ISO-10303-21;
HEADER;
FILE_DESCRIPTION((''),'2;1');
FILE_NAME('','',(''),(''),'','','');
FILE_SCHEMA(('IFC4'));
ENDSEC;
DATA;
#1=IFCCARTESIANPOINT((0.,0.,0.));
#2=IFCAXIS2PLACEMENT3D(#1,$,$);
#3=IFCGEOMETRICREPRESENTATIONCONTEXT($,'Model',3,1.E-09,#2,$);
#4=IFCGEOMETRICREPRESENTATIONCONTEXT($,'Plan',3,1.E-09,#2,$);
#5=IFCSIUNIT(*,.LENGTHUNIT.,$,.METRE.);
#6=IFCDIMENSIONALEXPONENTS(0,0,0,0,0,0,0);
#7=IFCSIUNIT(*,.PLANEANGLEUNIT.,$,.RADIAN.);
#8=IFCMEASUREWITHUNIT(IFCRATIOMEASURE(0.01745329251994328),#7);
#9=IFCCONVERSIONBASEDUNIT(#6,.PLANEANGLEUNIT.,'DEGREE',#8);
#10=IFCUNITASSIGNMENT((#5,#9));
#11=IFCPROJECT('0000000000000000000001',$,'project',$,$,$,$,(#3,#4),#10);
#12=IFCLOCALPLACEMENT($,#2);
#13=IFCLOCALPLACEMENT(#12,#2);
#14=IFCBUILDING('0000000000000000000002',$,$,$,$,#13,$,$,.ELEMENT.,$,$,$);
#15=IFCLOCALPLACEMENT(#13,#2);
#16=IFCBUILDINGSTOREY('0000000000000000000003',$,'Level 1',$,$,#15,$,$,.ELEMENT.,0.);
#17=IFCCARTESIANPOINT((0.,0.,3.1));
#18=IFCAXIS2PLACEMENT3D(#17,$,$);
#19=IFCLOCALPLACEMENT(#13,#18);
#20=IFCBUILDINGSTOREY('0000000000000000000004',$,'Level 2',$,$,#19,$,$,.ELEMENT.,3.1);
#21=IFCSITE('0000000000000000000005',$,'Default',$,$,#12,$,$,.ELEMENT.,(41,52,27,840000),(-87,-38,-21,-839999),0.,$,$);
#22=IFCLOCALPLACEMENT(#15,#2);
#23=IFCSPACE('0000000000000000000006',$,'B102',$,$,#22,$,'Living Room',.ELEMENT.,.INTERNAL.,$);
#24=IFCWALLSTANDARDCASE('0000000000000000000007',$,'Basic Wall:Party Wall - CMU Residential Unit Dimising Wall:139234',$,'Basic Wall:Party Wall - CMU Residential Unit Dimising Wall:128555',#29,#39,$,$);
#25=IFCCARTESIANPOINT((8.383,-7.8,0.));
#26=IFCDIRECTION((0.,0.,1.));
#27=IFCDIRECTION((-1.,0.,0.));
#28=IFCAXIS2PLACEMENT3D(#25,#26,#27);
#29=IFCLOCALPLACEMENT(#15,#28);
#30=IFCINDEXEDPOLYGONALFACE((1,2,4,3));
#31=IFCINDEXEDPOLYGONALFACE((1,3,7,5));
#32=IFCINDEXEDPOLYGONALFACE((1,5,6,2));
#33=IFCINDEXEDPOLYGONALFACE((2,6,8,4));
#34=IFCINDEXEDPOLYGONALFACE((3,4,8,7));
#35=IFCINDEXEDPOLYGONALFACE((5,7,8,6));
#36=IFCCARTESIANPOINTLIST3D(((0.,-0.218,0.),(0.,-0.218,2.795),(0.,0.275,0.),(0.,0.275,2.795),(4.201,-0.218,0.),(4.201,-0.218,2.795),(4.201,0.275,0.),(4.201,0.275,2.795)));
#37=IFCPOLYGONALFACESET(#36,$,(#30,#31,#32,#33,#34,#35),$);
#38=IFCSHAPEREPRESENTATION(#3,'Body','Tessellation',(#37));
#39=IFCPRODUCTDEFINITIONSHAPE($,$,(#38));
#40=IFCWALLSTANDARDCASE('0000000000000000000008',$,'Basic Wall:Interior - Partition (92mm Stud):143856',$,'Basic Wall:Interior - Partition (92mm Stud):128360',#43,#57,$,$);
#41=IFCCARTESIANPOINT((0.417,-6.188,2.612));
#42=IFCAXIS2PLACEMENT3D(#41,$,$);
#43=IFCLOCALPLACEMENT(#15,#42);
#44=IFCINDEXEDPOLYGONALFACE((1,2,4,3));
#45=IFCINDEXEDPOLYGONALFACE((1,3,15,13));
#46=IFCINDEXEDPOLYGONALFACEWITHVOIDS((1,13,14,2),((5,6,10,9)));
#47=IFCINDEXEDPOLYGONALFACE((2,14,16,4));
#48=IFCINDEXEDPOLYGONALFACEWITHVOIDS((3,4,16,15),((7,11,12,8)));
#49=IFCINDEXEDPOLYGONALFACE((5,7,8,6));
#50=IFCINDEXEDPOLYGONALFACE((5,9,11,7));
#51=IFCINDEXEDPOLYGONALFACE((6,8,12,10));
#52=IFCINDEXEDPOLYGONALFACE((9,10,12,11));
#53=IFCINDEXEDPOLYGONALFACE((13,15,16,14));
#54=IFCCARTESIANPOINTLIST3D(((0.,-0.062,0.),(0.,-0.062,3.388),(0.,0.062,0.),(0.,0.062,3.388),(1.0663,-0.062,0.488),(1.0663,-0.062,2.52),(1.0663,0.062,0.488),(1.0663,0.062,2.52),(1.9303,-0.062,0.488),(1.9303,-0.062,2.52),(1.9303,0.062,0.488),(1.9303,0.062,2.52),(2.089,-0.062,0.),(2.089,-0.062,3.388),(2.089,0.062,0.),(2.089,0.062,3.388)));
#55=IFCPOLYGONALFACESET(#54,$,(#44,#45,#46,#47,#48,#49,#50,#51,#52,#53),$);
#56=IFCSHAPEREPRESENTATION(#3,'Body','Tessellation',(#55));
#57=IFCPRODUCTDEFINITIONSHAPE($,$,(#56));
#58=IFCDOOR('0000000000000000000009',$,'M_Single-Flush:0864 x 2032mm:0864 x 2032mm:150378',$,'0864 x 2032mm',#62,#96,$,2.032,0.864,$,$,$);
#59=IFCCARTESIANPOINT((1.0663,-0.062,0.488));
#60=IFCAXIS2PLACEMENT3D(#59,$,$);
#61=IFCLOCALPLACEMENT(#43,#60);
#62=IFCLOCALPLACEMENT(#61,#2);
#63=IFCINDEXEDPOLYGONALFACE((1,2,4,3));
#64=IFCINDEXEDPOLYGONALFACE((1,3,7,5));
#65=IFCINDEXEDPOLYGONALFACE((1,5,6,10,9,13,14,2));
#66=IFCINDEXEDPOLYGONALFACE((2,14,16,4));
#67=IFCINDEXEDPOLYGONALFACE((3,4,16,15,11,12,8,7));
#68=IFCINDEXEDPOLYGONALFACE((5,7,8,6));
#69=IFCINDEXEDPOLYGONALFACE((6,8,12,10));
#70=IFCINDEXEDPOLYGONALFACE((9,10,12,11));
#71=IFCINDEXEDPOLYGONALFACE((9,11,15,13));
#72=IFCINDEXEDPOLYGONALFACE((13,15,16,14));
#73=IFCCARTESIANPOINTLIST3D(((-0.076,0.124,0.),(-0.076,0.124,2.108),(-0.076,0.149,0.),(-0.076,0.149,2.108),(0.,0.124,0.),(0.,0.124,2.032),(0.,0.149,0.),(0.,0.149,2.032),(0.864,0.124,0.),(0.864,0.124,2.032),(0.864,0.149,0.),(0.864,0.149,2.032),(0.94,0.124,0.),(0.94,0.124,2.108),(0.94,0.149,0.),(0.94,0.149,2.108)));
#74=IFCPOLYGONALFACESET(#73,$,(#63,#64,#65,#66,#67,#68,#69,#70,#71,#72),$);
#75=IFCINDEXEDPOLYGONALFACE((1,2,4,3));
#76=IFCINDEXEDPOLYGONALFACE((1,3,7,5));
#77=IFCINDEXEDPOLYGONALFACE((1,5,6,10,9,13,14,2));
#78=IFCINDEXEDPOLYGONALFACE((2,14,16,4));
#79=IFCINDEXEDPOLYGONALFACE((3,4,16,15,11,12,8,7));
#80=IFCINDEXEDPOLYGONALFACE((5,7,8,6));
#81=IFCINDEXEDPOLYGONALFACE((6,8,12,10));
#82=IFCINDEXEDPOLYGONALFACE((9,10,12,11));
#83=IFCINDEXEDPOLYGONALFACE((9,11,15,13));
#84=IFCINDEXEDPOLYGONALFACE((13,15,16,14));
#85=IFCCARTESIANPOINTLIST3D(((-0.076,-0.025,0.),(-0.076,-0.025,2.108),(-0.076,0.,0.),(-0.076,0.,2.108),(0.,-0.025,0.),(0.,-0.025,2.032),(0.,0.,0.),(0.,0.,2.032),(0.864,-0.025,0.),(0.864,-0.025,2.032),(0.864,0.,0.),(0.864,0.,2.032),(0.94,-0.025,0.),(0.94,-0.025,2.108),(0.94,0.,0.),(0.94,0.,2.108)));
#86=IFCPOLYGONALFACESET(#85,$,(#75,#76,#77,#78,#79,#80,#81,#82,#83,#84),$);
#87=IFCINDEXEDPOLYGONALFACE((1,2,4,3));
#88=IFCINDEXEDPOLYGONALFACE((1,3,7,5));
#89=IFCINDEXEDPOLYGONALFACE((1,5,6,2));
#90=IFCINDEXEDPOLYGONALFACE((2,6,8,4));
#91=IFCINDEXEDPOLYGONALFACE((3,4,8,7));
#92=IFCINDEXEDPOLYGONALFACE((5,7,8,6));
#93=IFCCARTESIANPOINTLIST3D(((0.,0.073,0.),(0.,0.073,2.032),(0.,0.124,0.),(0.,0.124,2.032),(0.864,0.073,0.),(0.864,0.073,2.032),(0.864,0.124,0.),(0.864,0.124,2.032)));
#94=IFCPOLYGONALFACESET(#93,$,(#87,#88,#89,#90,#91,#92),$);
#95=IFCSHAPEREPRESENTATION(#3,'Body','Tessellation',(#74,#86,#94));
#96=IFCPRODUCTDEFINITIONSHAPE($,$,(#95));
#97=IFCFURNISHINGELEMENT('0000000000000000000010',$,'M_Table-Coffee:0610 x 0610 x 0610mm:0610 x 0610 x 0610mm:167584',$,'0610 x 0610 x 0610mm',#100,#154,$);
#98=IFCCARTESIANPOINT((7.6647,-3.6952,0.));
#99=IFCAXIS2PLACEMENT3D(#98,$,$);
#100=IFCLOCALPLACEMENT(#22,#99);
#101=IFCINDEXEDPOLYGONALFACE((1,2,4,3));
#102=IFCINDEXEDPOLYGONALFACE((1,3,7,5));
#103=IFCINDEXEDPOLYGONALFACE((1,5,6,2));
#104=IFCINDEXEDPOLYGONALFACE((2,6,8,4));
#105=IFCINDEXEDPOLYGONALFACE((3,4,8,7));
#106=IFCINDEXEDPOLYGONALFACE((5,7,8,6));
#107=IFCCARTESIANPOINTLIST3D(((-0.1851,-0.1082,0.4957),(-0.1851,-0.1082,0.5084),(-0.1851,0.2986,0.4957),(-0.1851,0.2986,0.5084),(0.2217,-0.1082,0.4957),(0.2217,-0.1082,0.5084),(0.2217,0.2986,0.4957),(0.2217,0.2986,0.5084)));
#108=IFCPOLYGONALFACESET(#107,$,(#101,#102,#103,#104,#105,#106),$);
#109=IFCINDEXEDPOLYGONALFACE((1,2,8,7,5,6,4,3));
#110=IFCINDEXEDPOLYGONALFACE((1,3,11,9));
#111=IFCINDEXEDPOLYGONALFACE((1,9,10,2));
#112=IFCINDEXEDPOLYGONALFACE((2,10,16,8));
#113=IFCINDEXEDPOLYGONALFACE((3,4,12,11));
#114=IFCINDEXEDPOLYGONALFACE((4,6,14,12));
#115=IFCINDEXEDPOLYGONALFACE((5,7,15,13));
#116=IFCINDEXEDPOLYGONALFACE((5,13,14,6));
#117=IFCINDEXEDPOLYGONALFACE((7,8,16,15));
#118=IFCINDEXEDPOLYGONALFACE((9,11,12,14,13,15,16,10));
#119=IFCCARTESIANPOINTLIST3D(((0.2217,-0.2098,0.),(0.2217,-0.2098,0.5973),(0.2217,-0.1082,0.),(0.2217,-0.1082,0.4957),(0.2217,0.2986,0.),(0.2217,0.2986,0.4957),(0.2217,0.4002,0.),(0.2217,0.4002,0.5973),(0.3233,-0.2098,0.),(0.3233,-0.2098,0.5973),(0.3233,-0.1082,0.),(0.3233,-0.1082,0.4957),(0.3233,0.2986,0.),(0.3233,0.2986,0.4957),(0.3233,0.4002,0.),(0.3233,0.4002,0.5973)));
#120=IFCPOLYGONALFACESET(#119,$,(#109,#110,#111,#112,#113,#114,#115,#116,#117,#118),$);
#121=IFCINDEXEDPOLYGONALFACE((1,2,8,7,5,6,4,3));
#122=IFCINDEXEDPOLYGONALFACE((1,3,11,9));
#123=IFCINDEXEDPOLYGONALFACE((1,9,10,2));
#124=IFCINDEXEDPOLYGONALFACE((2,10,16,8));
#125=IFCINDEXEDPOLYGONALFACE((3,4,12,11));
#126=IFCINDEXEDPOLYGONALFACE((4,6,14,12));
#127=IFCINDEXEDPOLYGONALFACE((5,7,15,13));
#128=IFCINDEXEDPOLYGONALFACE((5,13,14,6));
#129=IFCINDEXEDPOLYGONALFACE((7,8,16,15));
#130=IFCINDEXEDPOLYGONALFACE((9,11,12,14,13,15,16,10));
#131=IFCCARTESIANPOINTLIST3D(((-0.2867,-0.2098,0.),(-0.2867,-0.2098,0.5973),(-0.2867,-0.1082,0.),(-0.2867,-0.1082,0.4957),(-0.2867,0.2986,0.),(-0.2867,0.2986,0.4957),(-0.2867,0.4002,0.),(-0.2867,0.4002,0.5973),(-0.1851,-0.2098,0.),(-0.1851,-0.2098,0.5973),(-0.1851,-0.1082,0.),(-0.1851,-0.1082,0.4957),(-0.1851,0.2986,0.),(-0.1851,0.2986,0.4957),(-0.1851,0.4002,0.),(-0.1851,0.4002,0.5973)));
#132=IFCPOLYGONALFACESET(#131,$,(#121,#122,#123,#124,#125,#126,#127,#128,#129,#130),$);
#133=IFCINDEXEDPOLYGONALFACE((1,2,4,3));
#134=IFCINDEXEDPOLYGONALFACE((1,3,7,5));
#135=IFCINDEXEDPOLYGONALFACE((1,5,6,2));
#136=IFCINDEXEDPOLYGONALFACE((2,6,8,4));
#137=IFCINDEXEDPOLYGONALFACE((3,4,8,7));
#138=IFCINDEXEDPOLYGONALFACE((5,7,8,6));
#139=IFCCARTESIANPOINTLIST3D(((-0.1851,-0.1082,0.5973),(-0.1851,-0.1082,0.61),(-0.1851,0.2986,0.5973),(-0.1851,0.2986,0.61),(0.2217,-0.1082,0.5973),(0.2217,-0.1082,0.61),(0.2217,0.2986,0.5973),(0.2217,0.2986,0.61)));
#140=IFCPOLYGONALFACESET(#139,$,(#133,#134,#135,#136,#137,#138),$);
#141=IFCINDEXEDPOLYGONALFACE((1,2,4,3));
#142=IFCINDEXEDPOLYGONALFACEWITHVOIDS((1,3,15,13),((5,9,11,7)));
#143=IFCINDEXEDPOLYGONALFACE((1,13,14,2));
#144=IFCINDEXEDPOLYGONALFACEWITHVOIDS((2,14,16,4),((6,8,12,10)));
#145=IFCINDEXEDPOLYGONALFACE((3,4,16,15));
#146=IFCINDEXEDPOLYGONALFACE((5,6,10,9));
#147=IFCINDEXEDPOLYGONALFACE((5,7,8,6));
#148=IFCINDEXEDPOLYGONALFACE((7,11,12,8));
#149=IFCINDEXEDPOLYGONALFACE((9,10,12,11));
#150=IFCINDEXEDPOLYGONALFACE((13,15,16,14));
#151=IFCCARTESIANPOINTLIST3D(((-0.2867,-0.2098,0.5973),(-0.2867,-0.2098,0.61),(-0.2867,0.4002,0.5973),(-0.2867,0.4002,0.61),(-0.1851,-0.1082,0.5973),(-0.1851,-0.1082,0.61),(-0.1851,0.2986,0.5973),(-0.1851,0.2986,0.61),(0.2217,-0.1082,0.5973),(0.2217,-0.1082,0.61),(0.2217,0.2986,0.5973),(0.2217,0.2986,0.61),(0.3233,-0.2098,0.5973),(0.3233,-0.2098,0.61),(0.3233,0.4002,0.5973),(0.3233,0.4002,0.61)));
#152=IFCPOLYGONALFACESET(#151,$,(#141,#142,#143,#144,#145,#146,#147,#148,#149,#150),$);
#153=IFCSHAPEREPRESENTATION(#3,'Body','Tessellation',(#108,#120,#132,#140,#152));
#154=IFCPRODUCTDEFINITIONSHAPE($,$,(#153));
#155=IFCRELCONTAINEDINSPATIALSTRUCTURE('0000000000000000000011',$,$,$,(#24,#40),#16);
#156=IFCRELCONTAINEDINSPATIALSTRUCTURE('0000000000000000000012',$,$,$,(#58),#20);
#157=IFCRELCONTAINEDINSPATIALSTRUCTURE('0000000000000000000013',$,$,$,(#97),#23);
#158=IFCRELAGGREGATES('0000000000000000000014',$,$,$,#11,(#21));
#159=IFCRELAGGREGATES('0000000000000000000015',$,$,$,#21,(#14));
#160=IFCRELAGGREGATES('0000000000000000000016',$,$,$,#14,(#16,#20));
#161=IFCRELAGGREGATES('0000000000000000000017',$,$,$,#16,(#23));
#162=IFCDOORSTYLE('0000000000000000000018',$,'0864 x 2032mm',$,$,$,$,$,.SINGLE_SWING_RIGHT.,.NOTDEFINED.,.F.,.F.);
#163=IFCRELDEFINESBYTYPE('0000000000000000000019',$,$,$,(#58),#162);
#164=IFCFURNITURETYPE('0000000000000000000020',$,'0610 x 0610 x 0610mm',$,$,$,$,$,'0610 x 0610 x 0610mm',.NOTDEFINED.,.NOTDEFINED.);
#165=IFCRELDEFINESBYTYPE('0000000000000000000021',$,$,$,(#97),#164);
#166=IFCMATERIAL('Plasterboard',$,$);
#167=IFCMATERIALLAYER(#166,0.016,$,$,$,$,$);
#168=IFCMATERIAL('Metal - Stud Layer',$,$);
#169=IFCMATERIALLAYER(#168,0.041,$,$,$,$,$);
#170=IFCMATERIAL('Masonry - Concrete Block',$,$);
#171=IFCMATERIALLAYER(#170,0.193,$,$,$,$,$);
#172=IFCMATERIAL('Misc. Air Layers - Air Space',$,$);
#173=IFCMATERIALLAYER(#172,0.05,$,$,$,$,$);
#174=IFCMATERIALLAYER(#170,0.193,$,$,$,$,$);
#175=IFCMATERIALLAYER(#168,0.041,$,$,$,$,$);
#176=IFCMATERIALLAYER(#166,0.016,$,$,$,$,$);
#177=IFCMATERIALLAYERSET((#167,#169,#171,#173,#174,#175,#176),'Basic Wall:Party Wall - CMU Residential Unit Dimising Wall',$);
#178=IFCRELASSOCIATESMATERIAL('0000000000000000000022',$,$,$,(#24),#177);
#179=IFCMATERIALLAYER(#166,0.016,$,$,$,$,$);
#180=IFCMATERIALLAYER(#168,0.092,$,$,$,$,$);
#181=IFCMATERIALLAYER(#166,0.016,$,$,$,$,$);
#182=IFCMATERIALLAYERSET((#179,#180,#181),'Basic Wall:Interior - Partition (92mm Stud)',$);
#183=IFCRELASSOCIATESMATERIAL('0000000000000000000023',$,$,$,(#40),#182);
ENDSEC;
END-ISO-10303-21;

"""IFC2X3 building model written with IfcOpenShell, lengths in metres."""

from ifc_helpers import new_model, entity, si_unit, converted_unit, frame, frame_2d, origin, origin_2d_with_axis, place, context, project, spatial, polyline, rectangle, outline, extrude, clip, bounded_halfspace, source, transform, mapped, material, layer, layer_set, layer_usage, type_object, type_shapes, element, fill, save


model = new_model("IFC2X3")

# Units and contexts
model_context = context("Model", 3, precision=1e-09, world=origin())
plan_context = context("Plan", 3, precision=1e-09, world=origin())
ifc_project = project(units=[si_unit("LENGTHUNIT", "METRE"), converted_unit("PLANEANGLEUNIT", "DEGREE", entity("IfcRatioMeasure", 0.01745329251994328), si_unit("PLANEANGLEUNIT", "RADIAN"), dimensions=[0, 0, 0, 0, 0, 0, 0])], contexts=[model_context, plan_context])

# Site, building, storey
site_placement = place(None, origin())
site = spatial("IfcSite", under=ifc_project, at=site_placement, Name="Default", CompositionType="ELEMENT", RefLatitude=(41, 52, 27, 840000), RefLongitude=(-87, -38, -21, -839999), RefElevation=0.0)
building_placement = place(site_placement, origin())
building = spatial("IfcBuilding", under=site, at=building_placement, CompositionType="ELEMENT")
storey_1_placement = place(building_placement, origin())
storey_1 = spatial("IfcBuildingStorey", under=building, at=storey_1_placement, Name="Level 1", CompositionType="ELEMENT", Elevation=0.0)

# Shared definitions
ifc_material_1 = material(Name="Misc. Air Layers - Air Space")
ifc_material_2 = material(Name="Masonry - Concrete Block")
ifc_material_3 = material(Name="Metal - Stud Layer")
ifc_material_4 = material(Name="Plasterboard")

# Wall
ifc_layer_1 = layer(ifc_material_4, 0.016)
ifc_layer_2 = layer(ifc_material_3, 0.041)
ifc_layer_3 = layer(ifc_material_2, 0.193)
ifc_layer_4 = layer(ifc_material_1, 0.05)
ifc_layer_5 = layer(ifc_material_2, 0.193)
ifc_layer_6 = layer(ifc_material_3, 0.041)
ifc_layer_7 = layer(ifc_material_4, 0.016)
ifc_layer_set_1 = layer_set([ifc_layer_1, ifc_layer_2, ifc_layer_3, ifc_layer_4, ifc_layer_5, ifc_layer_6, ifc_layer_7], Name="Basic Wall:Party Wall - CMU Residential Unit Dimising Wall")
ifc_layer_usage_1 = layer_usage(ifc_layer_set_1, "AXIS2", "NEGATIVE", 0.275)
wall_1_placement = place(storey_1_placement, frame((8.383, -7.8, 0.0), z_axis=(0.0, 0.0, 1.0), x_axis=(-1.0, 0.0, 0.0)))
element("IfcWallStandardCase", 1, at=wall_1_placement, inside=storey_1, material=ifc_layer_usage_1, Name="Basic Wall:Party Wall - CMU Residential Unit Dimising Wall:139234", ObjectType="Basic Wall:Party Wall - CMU Residential Unit Dimising Wall:128555", context=model_context, shape_type="Clipping", body=[
    clip(clip(extrude(rectangle(XDim=4.201, YDim=0.55, at=frame_2d((2.1005, 0.0), x_axis=(-1.0, 0.0))), origin(), (0.0, 0.0, 1.0), 2.795), bounded_halfspace(frame((0.0, -0.218, 2.795), z_axis=(0.0, 1.0, 0.0), x_axis=(-1.0, 0.0, 0.0)), True, frame((0.0, -0.218, 2.795), z_axis=(0.0, 1.0, 0.0), x_axis=(-1.0, 0.0, 0.0)), polyline([(0.0, 0.0), (-3.708, 0.0), (-4.201, 0.0), (-4.201, -2.795), (0.0, -2.795), (0.0, 0.0)]))), bounded_halfspace(frame((4.201, 0.275, 0.0), z_axis=(-1.0, 0.0, 0.0), x_axis=(0.0, -1.0, 0.0)), True, frame((4.201, 0.275, 0.0), z_axis=(-1.0, 0.0, 0.0), x_axis=(0.0, -1.0, 0.0)), polyline([(0.0, 0.0), (0.493, 0.0), (0.493, 2.795), (0.0, 2.795), (0.0, 0.0)]))),
])

# Wall, opening
ifc_layer_8 = layer(ifc_material_4, 0.016)
ifc_layer_9 = layer(ifc_material_3, 0.092)
ifc_layer_10 = layer(ifc_material_4, 0.016)
ifc_layer_set_2 = layer_set([ifc_layer_8, ifc_layer_9, ifc_layer_10], Name="Basic Wall:Interior - Partition (92mm Stud)")
ifc_layer_usage_2 = layer_usage(ifc_layer_set_2, "AXIS2", "NEGATIVE", 0.062)
wall_2_placement = place(storey_1_placement, frame((0.417, -6.188, 2.612)))
wall_2 = element("IfcWallStandardCase", 2, at=wall_2_placement, inside=storey_1, material=ifc_layer_usage_2, Name="Basic Wall:Interior - Partition (92mm Stud):143856", ObjectType="Basic Wall:Interior - Partition (92mm Stud):128360", context=model_context, shape_type="SweptSolid", body=[
    extrude(rectangle(XDim=2.089, YDim=0.124, at=frame_2d((1.0445, 0.0), x_axis=(-1.0, 0.0))), origin(), (0.0, 0.0, 1.0), 3.388),
])
opening_1_placement = place(wall_2_placement, frame((1.0663, -0.062, 0.488)))
opening_1 = element("IfcOpeningElement", 3, at=opening_1_placement, cuts=wall_2, ObjectType="Opening", context=model_context, shape_type="SweptSolid", body=[
    extrude(rectangle(XDim=0.864, YDim=2.032, at=frame_2d((1.016, 0.432), x_axis=(0.0, 1.0))), frame((0.0, 0.0, 0.0), z_axis=(0.0, 1.0, 0.0), x_axis=(0.0, 0.0, 1.0)), (0.0, 0.0, 1.0), 0.124),
])

# Shared definitions
storey_2_placement = place(building_placement, frame((0.0, 0.0, 3.1)))
storey_2 = spatial("IfcBuildingStorey", under=building, at=storey_2_placement, Name="Level 2", CompositionType="ELEMENT", Elevation=3.1)

# Door
door_style_1 = type_object("IfcDoorStyle", Name="0864 x 2032mm", ConstructionType="NOTDEFINED", OperationType="SINGLE_SWING_RIGHT", ParameterTakesPrecedence=False, Sizeable=False)
shared_shape_1 = source(origin(), model_context, "Body", "SweptSolid", [
    extrude(outline(polyline([(-0.508, -1.073), (0.508, -1.073), (0.508, 1.035), (0.432, 1.035), (0.432, -0.997), (-0.432, -0.997), (-0.432, 1.035), (-0.508, 1.035), (-0.508, -1.073)])), frame((0.432, 0.124, 1.035), z_axis=(0.0, 1.0, 0.0), x_axis=(1.0, 0.0, 0.0)), (0.0, 0.0, 1.0), 0.025),
    extrude(outline(polyline([(-1.073, -0.508), (1.035, -0.508), (1.035, -0.432), (-0.997, -0.432), (-0.997, 0.432), (1.035, 0.432), (1.035, 0.508), (-1.073, 0.508), (-1.073, -0.508)])), frame((0.432, -0.025, 1.035), z_axis=(0.0, 1.0, 0.0), x_axis=(0.0, 0.0, -1.0)), (0.0, 0.0, 1.0), 0.025),
    extrude(rectangle(XDim=0.051, YDim=0.864, at=origin_2d_with_axis()), frame((0.432, 0.0985, 0.0), z_axis=(0.0, 0.0, 1.0), x_axis=(0.0, 1.0, 0.0)), (0.0, 0.0, 1.0), 2.032),
])
type_shapes(door_style_1, [shared_shape_1])
door_1_placement = place(opening_1_placement, origin())
door_1 = element("IfcDoor", 4, at=door_1_placement, inside=storey_2, type_object=door_style_1, Name="M_Single-Flush:0864 x 2032mm:0864 x 2032mm:150378", ObjectType="0864 x 2032mm", OverallHeight=2.032, OverallWidth=0.864, context=model_context, shape_type="MappedRepresentation", body=[
    mapped(shared_shape_1, transform((0.0, 0.0, 0.0), scale=1.0)),
])
fill(opening_1, door_1)

# Shared definitions
space_1_placement = place(storey_1_placement, origin())
space_1 = spatial("IfcSpace", under=storey_1, at=space_1_placement, Name="B102", LongName="Living Room", CompositionType="ELEMENT", InteriorOrExteriorSpace="INTERNAL")

# Furnishing element
furniture_type_1 = type_object("IfcFurnitureType", Name="0610 x 0610 x 0610mm", ElementType="0610 x 0610 x 0610mm", AssemblyPlace="NOTDEFINED")
shared_shape_2 = source(origin(), model_context, "Body", "SweptSolid", [
    extrude(rectangle(XDim=0.4068, YDim=0.4068, at=origin_2d_with_axis()), frame((0.0183, 0.0952, 0.4957), z_axis=(0.0, 0.0, 1.0), x_axis=(-1.0, 0.0, 0.0)), (0.0, 0.0, 1.0), 0.0127),
    extrude(outline(polyline([(-0.2732, -0.305), (0.324, -0.305), (0.324, 0.305), (-0.2732, 0.305), (-0.2732, 0.2034), (0.2225, 0.2034), (0.2225, -0.2034), (-0.2732, -0.2034), (-0.2732, -0.305)])), frame((0.2217, 0.0952, 0.2732), z_axis=(1.0, 0.0, 0.0), x_axis=(0.0, 0.0, 1.0)), (0.0, 0.0, 1.0), 0.1016),
    extrude(outline(polyline([(-0.305, -0.3241), (0.305, -0.3241), (0.305, 0.2733), (0.2034, 0.2733), (0.2034, -0.2224), (-0.2034, -0.2224), (-0.2034, 0.2733), (-0.305, 0.2733), (-0.305, -0.3241)])), frame((-0.2867, 0.0952, 0.2733), z_axis=(1.0, 0.0, 0.0), x_axis=(0.0, -1.0, 0.0)), (0.0, 0.0, 1.0), 0.1016),
    extrude(rectangle(XDim=0.4068, YDim=0.4068, at=origin_2d_with_axis()), frame((0.0183, 0.0952, 0.5973), z_axis=(0.0, 0.0, 1.0), x_axis=(-1.0, 0.0, 0.0)), (0.0, 0.0, 1.0), 0.0127),
    extrude(outline(polyline([(-0.305, -0.305), (0.305, -0.305), (0.305, 0.305), (-0.305, 0.305), (-0.305, -0.305)]), holes=[polyline([(-0.2034, -0.2034), (-0.2034, 0.2034), (0.2034, 0.2034), (0.2034, -0.2034), (-0.2034, -0.2034)])]), frame((0.0183, 0.0952, 0.5973), z_axis=(0.0, 0.0, 1.0), x_axis=(-1.0, 0.0, 0.0)), (0.0, 0.0, 1.0), 0.0127),
])
type_shapes(furniture_type_1, [shared_shape_2])
for number, where, name in (
    (5, (7.6647, -3.6952, 0.0), "M_Table-Coffee:0610 x 0610 x 0610mm:0610 x 0610 x 0610mm:167584"),
):
    element("IfcFurnishingElement", number, at=place(space_1_placement, frame(where)), inside=space_1, type_object=furniture_type_1, Name=name, ObjectType="0610 x 0610 x 0610mm", context=model_context, shape_type="MappedRepresentation", body=[
        mapped(shared_shape_2, transform((0.0, 0.0, 0.0), scale=1.0)),
    ])

save(model, "model.ifc")
